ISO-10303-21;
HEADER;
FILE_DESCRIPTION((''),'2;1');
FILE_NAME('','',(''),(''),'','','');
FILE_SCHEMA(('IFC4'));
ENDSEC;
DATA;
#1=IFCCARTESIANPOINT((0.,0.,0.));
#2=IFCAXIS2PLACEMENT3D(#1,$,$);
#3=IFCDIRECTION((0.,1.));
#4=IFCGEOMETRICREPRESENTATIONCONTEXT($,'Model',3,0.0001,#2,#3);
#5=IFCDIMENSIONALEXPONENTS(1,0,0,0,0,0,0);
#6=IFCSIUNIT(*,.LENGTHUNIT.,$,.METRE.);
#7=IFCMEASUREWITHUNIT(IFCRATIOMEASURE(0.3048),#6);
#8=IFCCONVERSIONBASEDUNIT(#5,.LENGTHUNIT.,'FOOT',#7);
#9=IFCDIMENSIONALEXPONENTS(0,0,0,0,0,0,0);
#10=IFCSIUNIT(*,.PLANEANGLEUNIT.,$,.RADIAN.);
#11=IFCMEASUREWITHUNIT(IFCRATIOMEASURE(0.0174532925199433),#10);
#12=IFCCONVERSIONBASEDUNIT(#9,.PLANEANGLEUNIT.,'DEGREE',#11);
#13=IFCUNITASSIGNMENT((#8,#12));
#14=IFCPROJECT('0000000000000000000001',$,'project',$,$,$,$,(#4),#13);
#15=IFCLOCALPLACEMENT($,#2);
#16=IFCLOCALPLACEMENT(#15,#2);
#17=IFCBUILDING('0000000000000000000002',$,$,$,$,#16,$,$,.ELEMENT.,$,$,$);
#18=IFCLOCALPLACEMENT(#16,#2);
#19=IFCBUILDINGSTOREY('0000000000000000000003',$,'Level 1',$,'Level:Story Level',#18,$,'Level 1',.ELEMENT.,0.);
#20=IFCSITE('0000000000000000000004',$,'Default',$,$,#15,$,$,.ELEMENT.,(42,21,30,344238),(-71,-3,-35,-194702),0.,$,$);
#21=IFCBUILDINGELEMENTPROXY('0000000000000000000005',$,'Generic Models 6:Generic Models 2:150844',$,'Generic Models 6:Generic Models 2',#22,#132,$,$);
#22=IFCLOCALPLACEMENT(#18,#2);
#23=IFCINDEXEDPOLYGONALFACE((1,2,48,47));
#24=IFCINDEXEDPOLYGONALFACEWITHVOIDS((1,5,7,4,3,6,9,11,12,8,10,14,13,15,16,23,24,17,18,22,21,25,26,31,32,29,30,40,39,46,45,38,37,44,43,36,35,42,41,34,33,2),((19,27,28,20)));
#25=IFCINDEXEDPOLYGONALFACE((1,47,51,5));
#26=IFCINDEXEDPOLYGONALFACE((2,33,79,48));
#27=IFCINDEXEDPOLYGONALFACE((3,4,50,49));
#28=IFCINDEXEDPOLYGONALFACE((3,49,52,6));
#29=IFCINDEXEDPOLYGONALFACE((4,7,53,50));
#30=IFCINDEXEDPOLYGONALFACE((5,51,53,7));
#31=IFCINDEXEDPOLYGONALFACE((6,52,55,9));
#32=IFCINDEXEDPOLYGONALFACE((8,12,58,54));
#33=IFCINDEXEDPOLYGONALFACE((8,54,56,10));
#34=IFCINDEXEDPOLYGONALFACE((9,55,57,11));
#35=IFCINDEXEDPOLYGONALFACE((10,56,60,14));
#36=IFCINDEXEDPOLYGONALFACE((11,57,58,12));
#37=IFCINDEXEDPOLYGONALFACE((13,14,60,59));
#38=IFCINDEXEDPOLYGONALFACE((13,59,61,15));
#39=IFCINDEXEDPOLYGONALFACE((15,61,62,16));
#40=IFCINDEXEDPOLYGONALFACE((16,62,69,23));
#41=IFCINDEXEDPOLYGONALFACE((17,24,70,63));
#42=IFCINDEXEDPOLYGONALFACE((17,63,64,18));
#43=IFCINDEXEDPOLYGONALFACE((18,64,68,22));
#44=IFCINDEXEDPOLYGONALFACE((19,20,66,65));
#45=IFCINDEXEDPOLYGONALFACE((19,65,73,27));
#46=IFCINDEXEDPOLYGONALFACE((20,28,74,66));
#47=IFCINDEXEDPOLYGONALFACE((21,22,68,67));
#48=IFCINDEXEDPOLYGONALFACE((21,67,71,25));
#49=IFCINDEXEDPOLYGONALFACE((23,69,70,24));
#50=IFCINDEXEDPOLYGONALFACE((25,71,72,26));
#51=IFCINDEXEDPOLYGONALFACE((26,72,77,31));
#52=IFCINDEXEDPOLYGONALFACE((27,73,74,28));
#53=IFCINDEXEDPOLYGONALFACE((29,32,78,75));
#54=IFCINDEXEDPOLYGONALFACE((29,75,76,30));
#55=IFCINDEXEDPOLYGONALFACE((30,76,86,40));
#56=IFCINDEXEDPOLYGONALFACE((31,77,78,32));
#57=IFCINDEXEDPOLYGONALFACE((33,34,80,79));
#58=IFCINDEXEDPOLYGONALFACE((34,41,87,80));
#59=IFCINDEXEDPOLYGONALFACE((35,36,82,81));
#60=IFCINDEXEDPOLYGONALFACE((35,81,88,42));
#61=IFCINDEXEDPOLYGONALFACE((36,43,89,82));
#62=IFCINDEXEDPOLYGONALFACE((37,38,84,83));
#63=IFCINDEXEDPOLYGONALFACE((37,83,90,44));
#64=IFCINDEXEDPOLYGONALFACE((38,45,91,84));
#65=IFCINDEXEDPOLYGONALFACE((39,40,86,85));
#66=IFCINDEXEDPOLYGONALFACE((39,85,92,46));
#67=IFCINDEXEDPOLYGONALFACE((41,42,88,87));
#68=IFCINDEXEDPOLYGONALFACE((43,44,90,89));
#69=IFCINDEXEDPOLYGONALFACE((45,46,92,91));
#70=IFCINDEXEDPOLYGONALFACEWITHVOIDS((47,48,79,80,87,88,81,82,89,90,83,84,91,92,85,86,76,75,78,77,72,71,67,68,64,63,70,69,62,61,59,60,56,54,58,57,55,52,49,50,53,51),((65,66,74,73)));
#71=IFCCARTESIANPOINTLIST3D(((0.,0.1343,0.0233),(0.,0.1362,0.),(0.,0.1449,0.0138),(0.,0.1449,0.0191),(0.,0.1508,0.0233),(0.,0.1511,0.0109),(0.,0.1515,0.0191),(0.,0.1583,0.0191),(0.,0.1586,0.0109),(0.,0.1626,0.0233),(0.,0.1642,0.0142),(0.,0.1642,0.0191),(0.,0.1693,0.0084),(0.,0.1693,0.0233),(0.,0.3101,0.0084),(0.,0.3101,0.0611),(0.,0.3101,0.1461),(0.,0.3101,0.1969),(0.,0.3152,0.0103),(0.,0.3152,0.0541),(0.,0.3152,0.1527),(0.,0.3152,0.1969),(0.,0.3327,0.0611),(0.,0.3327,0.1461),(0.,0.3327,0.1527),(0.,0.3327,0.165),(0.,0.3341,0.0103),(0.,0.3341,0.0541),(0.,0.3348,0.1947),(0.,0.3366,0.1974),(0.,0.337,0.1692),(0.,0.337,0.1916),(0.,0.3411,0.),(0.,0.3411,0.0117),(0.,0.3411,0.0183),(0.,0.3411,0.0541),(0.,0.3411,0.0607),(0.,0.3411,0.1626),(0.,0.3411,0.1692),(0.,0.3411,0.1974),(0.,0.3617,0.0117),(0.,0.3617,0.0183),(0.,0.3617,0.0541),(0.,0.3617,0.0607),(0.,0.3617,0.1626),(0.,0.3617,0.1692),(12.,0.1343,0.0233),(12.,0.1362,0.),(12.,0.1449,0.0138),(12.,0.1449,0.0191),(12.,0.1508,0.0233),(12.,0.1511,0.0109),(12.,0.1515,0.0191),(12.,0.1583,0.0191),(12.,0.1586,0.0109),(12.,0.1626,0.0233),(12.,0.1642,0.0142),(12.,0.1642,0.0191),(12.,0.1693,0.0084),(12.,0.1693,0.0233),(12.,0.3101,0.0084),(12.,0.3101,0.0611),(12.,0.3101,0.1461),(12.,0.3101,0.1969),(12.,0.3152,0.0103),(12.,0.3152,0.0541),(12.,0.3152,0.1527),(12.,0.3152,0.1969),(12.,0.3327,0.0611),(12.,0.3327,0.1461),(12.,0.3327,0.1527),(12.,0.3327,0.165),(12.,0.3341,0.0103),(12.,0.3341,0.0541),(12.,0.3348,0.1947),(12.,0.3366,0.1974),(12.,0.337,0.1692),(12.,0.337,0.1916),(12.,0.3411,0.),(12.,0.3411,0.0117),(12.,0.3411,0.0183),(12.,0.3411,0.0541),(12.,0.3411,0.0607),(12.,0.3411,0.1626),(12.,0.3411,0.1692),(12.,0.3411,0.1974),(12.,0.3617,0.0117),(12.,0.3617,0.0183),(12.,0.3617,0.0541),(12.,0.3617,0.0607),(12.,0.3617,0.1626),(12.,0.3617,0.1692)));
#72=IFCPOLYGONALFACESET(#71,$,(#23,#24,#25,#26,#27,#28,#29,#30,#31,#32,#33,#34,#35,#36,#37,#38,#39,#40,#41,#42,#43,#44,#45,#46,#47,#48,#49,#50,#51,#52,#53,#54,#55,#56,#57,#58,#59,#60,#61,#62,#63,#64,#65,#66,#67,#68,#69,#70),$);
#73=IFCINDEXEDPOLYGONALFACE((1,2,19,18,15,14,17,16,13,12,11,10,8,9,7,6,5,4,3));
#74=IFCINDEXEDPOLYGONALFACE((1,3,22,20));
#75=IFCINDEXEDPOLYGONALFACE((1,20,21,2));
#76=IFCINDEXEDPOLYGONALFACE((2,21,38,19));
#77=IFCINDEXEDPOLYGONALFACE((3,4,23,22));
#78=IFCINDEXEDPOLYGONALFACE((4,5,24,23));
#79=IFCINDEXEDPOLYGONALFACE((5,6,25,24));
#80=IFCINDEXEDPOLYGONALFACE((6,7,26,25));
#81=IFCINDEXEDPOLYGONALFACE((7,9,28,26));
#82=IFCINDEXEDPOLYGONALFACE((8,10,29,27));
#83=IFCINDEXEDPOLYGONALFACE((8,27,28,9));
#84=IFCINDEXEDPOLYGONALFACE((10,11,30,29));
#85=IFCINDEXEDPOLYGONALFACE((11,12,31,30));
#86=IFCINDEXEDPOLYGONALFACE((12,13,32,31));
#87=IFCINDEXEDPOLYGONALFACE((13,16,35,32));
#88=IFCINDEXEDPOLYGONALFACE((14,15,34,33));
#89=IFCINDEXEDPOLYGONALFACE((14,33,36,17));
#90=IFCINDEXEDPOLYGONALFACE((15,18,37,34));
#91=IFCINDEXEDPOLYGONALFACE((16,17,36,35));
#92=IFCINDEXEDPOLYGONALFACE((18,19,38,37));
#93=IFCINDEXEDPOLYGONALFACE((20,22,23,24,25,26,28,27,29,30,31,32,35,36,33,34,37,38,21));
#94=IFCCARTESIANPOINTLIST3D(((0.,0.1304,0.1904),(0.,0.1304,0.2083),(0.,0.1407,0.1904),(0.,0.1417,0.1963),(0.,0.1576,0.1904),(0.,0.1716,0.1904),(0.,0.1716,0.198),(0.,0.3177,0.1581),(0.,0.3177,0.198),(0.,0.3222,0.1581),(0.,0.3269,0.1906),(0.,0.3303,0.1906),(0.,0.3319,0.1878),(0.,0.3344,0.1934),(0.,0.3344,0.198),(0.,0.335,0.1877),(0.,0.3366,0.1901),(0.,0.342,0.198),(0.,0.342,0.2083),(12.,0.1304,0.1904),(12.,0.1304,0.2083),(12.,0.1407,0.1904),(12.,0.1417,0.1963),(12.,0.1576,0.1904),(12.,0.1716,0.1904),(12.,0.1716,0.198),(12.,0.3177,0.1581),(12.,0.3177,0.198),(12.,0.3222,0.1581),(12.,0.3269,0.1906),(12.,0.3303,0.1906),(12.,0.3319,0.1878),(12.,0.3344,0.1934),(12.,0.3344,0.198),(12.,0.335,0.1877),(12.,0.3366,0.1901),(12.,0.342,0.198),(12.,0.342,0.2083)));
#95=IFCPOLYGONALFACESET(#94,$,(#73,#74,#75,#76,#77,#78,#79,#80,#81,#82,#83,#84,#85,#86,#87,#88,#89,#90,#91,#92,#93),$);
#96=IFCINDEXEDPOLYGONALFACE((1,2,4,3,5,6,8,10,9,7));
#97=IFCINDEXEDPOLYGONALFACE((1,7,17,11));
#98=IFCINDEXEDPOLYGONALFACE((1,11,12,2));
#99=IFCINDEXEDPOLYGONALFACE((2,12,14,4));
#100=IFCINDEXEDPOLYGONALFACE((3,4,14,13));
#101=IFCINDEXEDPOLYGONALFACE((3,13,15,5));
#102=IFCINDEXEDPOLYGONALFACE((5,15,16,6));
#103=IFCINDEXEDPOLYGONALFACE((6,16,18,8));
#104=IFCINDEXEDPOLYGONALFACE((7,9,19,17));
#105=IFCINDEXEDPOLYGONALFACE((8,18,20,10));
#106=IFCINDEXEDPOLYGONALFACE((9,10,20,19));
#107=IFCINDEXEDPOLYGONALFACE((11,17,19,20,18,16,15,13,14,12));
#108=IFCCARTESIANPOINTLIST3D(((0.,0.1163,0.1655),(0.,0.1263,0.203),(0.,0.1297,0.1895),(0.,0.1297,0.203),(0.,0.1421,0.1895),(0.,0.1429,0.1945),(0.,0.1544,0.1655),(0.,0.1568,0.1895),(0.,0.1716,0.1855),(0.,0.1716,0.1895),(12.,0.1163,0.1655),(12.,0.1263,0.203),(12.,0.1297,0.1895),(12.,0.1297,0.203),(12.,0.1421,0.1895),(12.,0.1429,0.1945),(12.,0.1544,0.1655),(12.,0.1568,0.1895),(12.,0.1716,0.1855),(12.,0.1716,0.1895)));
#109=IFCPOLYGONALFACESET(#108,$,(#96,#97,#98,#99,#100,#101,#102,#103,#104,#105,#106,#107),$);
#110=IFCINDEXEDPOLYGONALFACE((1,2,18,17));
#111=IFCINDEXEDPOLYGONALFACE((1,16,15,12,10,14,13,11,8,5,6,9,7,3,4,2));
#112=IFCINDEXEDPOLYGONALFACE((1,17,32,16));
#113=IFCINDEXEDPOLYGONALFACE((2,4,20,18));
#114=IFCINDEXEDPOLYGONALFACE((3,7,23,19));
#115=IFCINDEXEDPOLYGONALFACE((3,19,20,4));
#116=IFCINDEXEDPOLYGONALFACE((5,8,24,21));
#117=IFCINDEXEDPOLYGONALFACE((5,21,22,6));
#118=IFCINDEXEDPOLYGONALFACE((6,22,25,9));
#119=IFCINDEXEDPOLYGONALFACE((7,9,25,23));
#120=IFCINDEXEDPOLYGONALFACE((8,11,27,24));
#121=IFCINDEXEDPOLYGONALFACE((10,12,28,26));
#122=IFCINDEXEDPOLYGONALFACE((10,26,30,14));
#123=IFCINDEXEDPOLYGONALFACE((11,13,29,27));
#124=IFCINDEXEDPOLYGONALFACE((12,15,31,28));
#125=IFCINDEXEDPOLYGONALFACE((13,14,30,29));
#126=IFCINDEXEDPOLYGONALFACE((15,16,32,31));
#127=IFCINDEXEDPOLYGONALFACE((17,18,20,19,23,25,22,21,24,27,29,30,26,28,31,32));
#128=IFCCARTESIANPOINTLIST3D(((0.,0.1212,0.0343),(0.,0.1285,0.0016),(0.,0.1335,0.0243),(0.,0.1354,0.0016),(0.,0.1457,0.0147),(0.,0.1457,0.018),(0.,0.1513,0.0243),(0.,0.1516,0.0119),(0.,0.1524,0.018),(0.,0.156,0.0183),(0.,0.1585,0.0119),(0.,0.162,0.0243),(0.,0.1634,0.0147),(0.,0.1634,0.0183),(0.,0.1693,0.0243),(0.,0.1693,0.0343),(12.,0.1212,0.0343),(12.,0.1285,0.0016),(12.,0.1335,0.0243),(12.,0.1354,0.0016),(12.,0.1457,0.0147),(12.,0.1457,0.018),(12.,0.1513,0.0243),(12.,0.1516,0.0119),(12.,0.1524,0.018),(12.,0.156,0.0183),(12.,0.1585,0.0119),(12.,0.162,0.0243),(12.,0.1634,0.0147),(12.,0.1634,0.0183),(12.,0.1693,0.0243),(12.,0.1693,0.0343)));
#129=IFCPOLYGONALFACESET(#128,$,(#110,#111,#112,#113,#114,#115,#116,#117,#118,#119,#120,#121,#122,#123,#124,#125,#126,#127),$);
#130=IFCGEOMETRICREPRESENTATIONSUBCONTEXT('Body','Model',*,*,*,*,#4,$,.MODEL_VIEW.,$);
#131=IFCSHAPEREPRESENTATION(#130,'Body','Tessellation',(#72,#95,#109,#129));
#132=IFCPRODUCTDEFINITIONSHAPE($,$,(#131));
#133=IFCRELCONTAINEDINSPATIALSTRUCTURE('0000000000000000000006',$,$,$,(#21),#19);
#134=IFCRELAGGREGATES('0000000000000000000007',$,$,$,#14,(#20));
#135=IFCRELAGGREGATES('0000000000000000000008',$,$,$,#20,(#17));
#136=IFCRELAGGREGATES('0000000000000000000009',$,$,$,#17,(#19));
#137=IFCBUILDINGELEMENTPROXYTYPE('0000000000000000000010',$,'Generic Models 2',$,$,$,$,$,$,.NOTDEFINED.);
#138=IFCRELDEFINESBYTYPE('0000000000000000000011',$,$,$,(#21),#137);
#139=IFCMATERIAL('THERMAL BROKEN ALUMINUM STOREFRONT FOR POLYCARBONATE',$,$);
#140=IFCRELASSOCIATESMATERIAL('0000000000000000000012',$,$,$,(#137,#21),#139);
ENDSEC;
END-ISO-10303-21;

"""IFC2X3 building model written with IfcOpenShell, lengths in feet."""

from ifc_helpers import new_model, entity, si_unit, converted_unit, direction, frame, origin, place, context, subcontext, project, spatial, polyline, outline, extrude, source, transform, mapped, material, type_object, type_shapes, element, save


model = new_model("IFC2X3")

# Units and contexts
model_context = context("Model", 3, precision=0.0001, world=origin(), true_north=direction((0.0, 1.0)))
body_context = subcontext(model_context, "Body", "Model", "MODEL_VIEW")
ifc_project = project(units=[converted_unit("LENGTHUNIT", "FOOT", entity("IfcRatioMeasure", 0.3048), si_unit("LENGTHUNIT", "METRE"), dimensions=[1, 0, 0, 0, 0, 0, 0]), converted_unit("PLANEANGLEUNIT", "DEGREE", entity("IfcRatioMeasure", 0.0174532925199433), si_unit("PLANEANGLEUNIT", "RADIAN"), dimensions=[0, 0, 0, 0, 0, 0, 0])], contexts=[model_context])

# Site, building, storey
site_placement = place(None, origin())
site = spatial("IfcSite", under=ifc_project, at=site_placement, Name="Default", CompositionType="ELEMENT", RefLatitude=(42, 21, 30, 344238), RefLongitude=(-71, -3, -35, -194702), RefElevation=0.0)
building_placement = place(site_placement, origin())
building = spatial("IfcBuilding", under=site, at=building_placement, CompositionType="ELEMENT")
storey_placement = place(building_placement, origin())
storey = spatial("IfcBuildingStorey", under=building, at=storey_placement, Name="Level 1", ObjectType="Level:Story Level", LongName="Level 1", CompositionType="ELEMENT", Elevation=0.0)

# Building element proxy
ifc_material = material(Name="THERMAL BROKEN ALUMINUM STOREFRONT FOR POLYCARBONATE")
building_element_proxy_type_1 = type_object("IfcBuildingElementProxyType", Name="Generic Models 2", PredefinedType="NOTDEFINED", material=ifc_material)
shared_shape_1 = source(origin(), body_context, "Body", "SweptSolid", [
    extrude(outline(polyline([(-0.073, 0.107), (-0.058, 0.107), (-0.058, 0.1137), (-0.0623, 0.118), (-0.0623, 0.1121), (-0.0672, 0.1121), (-0.0704, 0.1177), (-0.0704, 0.1252), (-0.0675, 0.1315), (-0.0623, 0.1315), (-0.0623, 0.1248), (-0.058, 0.1255), (-0.058, 0.142), (-0.0814, 0.1401), (-0.0814, -0.0647), (-0.0697, -0.0647), (-0.0697, -0.0853), (-0.0631, -0.0853), (-0.0631, -0.0647), (-0.0273, -0.0647), (-0.0273, -0.0853), (-0.0207, -0.0853), (-0.0207, -0.0647), (0.0812, -0.0647), (0.0812, -0.0853), (0.0878, -0.0853), (0.0878, -0.0647), (0.1161, -0.0647), (0.1161, -0.0603), (0.1133, -0.0585), (0.1102, -0.0606), (0.0878, -0.0606), (0.0836, -0.0564), (0.0713, -0.0564), (0.0713, -0.0389), (0.1155, -0.0389), (0.1155, -0.0338), (0.0647, -0.0338), (0.0647, -0.0564), (-0.0203, -0.0564), (-0.0203, -0.0338), (-0.073, -0.0338), (-0.073, 0.107)]), holes=[polyline([(-0.0711, -0.0577), (-0.0711, -0.0389), (-0.0273, -0.0389), (-0.0273, -0.0577), (-0.0711, -0.0577)])]), frame((0.0, 0.2763, -0.2198), z_axis=(1.0, 0.0, 0.0), x_axis=(0.0, 0.0, 1.0)), (0.0, 0.0, 1.0), 12.0),
    extrude(outline(polyline([(0.068, 0.0006), (0.0711, 0.0006), (0.0726, 0.0031), (0.0702, 0.0064), (0.07, 0.011), (0.0776, 0.0114), (0.0771, 0.0217), (-0.1343, 0.0107), (-0.1334, -0.0072), (-0.1231, -0.0066), (-0.1224, -0.0008), (-0.1062, -0.0058), (-0.0922, -0.005), (-0.0926, 0.0025), (0.0533, 0.0101), (0.0554, -0.0297), (0.0599, -0.0295), (0.0628, 0.0032), (0.0663, 0.0034), (0.068, 0.0006)])), frame((0.0, 0.264, -0.1105), z_axis=(1.0, 0.0, 0.0), x_axis=(0.0, 0.998659, -0.051774)), (0.0, 0.0, 1.0), 12.0),
    extrude(outline(polyline([(-0.0104, -0.0212), (0.0284, -0.0212), (0.0186, 0.0156), (-0.0052, 0.0271), (-0.009, 0.026), (-0.0051, 0.0117), (-0.0065, -0.003), (-0.0014, -0.0025), (0.0018, -0.0144), (-0.0113, -0.0179), (-0.0104, -0.0212)])), frame((0.0, 0.1442, -0.1136), z_axis=(1.0, 0.0, 0.0), x_axis=(0.0, -0.257663, -0.966235)), (0.0, 0.0, 1.0), 12.0),
    extrude(outline(polyline([(-0.0218, -0.0251), (0.0116, -0.0251), (0.0131, -0.0183), (-0.0094, -0.0153), (-0.0056, 0.0021), (0.0008, 0.0018), (-0.0006, -0.0047), (0.0027, -0.0054), (0.0066, -0.0003), (0.0081, 0.0064), (0.0064, 0.0118), (0.0029, 0.0126), (0.0013, 0.0053), (-0.0032, 0.0125), (-0.0017, 0.0197), (-0.0114, 0.0218), (-0.0218, -0.0251)])), frame((0.0, 0.1504, -0.2827), z_axis=(1.0, 0.0, 0.0), x_axis=(0.0, 0.217466, -0.976068)), (0.0, 0.0, 1.0), 12.0),
])
type_shapes(building_element_proxy_type_1, [shared_shape_1])
proxy_1_placement = place(storey_placement, frame((0.0, 0.0, 0.3012)))
element("IfcBuildingElementProxy", 1, at=proxy_1_placement, inside=storey, type_object=building_element_proxy_type_1, material=ifc_material, Name="Generic Models 6:Generic Models 2:150844", ObjectType="Generic Models 6:Generic Models 2", context=body_context, shape_type="MappedRepresentation", body=[
    mapped(shared_shape_1, transform((0.0, 0.0, 0.0), scale=1.0)),
])

save(model, "model.ifc")
